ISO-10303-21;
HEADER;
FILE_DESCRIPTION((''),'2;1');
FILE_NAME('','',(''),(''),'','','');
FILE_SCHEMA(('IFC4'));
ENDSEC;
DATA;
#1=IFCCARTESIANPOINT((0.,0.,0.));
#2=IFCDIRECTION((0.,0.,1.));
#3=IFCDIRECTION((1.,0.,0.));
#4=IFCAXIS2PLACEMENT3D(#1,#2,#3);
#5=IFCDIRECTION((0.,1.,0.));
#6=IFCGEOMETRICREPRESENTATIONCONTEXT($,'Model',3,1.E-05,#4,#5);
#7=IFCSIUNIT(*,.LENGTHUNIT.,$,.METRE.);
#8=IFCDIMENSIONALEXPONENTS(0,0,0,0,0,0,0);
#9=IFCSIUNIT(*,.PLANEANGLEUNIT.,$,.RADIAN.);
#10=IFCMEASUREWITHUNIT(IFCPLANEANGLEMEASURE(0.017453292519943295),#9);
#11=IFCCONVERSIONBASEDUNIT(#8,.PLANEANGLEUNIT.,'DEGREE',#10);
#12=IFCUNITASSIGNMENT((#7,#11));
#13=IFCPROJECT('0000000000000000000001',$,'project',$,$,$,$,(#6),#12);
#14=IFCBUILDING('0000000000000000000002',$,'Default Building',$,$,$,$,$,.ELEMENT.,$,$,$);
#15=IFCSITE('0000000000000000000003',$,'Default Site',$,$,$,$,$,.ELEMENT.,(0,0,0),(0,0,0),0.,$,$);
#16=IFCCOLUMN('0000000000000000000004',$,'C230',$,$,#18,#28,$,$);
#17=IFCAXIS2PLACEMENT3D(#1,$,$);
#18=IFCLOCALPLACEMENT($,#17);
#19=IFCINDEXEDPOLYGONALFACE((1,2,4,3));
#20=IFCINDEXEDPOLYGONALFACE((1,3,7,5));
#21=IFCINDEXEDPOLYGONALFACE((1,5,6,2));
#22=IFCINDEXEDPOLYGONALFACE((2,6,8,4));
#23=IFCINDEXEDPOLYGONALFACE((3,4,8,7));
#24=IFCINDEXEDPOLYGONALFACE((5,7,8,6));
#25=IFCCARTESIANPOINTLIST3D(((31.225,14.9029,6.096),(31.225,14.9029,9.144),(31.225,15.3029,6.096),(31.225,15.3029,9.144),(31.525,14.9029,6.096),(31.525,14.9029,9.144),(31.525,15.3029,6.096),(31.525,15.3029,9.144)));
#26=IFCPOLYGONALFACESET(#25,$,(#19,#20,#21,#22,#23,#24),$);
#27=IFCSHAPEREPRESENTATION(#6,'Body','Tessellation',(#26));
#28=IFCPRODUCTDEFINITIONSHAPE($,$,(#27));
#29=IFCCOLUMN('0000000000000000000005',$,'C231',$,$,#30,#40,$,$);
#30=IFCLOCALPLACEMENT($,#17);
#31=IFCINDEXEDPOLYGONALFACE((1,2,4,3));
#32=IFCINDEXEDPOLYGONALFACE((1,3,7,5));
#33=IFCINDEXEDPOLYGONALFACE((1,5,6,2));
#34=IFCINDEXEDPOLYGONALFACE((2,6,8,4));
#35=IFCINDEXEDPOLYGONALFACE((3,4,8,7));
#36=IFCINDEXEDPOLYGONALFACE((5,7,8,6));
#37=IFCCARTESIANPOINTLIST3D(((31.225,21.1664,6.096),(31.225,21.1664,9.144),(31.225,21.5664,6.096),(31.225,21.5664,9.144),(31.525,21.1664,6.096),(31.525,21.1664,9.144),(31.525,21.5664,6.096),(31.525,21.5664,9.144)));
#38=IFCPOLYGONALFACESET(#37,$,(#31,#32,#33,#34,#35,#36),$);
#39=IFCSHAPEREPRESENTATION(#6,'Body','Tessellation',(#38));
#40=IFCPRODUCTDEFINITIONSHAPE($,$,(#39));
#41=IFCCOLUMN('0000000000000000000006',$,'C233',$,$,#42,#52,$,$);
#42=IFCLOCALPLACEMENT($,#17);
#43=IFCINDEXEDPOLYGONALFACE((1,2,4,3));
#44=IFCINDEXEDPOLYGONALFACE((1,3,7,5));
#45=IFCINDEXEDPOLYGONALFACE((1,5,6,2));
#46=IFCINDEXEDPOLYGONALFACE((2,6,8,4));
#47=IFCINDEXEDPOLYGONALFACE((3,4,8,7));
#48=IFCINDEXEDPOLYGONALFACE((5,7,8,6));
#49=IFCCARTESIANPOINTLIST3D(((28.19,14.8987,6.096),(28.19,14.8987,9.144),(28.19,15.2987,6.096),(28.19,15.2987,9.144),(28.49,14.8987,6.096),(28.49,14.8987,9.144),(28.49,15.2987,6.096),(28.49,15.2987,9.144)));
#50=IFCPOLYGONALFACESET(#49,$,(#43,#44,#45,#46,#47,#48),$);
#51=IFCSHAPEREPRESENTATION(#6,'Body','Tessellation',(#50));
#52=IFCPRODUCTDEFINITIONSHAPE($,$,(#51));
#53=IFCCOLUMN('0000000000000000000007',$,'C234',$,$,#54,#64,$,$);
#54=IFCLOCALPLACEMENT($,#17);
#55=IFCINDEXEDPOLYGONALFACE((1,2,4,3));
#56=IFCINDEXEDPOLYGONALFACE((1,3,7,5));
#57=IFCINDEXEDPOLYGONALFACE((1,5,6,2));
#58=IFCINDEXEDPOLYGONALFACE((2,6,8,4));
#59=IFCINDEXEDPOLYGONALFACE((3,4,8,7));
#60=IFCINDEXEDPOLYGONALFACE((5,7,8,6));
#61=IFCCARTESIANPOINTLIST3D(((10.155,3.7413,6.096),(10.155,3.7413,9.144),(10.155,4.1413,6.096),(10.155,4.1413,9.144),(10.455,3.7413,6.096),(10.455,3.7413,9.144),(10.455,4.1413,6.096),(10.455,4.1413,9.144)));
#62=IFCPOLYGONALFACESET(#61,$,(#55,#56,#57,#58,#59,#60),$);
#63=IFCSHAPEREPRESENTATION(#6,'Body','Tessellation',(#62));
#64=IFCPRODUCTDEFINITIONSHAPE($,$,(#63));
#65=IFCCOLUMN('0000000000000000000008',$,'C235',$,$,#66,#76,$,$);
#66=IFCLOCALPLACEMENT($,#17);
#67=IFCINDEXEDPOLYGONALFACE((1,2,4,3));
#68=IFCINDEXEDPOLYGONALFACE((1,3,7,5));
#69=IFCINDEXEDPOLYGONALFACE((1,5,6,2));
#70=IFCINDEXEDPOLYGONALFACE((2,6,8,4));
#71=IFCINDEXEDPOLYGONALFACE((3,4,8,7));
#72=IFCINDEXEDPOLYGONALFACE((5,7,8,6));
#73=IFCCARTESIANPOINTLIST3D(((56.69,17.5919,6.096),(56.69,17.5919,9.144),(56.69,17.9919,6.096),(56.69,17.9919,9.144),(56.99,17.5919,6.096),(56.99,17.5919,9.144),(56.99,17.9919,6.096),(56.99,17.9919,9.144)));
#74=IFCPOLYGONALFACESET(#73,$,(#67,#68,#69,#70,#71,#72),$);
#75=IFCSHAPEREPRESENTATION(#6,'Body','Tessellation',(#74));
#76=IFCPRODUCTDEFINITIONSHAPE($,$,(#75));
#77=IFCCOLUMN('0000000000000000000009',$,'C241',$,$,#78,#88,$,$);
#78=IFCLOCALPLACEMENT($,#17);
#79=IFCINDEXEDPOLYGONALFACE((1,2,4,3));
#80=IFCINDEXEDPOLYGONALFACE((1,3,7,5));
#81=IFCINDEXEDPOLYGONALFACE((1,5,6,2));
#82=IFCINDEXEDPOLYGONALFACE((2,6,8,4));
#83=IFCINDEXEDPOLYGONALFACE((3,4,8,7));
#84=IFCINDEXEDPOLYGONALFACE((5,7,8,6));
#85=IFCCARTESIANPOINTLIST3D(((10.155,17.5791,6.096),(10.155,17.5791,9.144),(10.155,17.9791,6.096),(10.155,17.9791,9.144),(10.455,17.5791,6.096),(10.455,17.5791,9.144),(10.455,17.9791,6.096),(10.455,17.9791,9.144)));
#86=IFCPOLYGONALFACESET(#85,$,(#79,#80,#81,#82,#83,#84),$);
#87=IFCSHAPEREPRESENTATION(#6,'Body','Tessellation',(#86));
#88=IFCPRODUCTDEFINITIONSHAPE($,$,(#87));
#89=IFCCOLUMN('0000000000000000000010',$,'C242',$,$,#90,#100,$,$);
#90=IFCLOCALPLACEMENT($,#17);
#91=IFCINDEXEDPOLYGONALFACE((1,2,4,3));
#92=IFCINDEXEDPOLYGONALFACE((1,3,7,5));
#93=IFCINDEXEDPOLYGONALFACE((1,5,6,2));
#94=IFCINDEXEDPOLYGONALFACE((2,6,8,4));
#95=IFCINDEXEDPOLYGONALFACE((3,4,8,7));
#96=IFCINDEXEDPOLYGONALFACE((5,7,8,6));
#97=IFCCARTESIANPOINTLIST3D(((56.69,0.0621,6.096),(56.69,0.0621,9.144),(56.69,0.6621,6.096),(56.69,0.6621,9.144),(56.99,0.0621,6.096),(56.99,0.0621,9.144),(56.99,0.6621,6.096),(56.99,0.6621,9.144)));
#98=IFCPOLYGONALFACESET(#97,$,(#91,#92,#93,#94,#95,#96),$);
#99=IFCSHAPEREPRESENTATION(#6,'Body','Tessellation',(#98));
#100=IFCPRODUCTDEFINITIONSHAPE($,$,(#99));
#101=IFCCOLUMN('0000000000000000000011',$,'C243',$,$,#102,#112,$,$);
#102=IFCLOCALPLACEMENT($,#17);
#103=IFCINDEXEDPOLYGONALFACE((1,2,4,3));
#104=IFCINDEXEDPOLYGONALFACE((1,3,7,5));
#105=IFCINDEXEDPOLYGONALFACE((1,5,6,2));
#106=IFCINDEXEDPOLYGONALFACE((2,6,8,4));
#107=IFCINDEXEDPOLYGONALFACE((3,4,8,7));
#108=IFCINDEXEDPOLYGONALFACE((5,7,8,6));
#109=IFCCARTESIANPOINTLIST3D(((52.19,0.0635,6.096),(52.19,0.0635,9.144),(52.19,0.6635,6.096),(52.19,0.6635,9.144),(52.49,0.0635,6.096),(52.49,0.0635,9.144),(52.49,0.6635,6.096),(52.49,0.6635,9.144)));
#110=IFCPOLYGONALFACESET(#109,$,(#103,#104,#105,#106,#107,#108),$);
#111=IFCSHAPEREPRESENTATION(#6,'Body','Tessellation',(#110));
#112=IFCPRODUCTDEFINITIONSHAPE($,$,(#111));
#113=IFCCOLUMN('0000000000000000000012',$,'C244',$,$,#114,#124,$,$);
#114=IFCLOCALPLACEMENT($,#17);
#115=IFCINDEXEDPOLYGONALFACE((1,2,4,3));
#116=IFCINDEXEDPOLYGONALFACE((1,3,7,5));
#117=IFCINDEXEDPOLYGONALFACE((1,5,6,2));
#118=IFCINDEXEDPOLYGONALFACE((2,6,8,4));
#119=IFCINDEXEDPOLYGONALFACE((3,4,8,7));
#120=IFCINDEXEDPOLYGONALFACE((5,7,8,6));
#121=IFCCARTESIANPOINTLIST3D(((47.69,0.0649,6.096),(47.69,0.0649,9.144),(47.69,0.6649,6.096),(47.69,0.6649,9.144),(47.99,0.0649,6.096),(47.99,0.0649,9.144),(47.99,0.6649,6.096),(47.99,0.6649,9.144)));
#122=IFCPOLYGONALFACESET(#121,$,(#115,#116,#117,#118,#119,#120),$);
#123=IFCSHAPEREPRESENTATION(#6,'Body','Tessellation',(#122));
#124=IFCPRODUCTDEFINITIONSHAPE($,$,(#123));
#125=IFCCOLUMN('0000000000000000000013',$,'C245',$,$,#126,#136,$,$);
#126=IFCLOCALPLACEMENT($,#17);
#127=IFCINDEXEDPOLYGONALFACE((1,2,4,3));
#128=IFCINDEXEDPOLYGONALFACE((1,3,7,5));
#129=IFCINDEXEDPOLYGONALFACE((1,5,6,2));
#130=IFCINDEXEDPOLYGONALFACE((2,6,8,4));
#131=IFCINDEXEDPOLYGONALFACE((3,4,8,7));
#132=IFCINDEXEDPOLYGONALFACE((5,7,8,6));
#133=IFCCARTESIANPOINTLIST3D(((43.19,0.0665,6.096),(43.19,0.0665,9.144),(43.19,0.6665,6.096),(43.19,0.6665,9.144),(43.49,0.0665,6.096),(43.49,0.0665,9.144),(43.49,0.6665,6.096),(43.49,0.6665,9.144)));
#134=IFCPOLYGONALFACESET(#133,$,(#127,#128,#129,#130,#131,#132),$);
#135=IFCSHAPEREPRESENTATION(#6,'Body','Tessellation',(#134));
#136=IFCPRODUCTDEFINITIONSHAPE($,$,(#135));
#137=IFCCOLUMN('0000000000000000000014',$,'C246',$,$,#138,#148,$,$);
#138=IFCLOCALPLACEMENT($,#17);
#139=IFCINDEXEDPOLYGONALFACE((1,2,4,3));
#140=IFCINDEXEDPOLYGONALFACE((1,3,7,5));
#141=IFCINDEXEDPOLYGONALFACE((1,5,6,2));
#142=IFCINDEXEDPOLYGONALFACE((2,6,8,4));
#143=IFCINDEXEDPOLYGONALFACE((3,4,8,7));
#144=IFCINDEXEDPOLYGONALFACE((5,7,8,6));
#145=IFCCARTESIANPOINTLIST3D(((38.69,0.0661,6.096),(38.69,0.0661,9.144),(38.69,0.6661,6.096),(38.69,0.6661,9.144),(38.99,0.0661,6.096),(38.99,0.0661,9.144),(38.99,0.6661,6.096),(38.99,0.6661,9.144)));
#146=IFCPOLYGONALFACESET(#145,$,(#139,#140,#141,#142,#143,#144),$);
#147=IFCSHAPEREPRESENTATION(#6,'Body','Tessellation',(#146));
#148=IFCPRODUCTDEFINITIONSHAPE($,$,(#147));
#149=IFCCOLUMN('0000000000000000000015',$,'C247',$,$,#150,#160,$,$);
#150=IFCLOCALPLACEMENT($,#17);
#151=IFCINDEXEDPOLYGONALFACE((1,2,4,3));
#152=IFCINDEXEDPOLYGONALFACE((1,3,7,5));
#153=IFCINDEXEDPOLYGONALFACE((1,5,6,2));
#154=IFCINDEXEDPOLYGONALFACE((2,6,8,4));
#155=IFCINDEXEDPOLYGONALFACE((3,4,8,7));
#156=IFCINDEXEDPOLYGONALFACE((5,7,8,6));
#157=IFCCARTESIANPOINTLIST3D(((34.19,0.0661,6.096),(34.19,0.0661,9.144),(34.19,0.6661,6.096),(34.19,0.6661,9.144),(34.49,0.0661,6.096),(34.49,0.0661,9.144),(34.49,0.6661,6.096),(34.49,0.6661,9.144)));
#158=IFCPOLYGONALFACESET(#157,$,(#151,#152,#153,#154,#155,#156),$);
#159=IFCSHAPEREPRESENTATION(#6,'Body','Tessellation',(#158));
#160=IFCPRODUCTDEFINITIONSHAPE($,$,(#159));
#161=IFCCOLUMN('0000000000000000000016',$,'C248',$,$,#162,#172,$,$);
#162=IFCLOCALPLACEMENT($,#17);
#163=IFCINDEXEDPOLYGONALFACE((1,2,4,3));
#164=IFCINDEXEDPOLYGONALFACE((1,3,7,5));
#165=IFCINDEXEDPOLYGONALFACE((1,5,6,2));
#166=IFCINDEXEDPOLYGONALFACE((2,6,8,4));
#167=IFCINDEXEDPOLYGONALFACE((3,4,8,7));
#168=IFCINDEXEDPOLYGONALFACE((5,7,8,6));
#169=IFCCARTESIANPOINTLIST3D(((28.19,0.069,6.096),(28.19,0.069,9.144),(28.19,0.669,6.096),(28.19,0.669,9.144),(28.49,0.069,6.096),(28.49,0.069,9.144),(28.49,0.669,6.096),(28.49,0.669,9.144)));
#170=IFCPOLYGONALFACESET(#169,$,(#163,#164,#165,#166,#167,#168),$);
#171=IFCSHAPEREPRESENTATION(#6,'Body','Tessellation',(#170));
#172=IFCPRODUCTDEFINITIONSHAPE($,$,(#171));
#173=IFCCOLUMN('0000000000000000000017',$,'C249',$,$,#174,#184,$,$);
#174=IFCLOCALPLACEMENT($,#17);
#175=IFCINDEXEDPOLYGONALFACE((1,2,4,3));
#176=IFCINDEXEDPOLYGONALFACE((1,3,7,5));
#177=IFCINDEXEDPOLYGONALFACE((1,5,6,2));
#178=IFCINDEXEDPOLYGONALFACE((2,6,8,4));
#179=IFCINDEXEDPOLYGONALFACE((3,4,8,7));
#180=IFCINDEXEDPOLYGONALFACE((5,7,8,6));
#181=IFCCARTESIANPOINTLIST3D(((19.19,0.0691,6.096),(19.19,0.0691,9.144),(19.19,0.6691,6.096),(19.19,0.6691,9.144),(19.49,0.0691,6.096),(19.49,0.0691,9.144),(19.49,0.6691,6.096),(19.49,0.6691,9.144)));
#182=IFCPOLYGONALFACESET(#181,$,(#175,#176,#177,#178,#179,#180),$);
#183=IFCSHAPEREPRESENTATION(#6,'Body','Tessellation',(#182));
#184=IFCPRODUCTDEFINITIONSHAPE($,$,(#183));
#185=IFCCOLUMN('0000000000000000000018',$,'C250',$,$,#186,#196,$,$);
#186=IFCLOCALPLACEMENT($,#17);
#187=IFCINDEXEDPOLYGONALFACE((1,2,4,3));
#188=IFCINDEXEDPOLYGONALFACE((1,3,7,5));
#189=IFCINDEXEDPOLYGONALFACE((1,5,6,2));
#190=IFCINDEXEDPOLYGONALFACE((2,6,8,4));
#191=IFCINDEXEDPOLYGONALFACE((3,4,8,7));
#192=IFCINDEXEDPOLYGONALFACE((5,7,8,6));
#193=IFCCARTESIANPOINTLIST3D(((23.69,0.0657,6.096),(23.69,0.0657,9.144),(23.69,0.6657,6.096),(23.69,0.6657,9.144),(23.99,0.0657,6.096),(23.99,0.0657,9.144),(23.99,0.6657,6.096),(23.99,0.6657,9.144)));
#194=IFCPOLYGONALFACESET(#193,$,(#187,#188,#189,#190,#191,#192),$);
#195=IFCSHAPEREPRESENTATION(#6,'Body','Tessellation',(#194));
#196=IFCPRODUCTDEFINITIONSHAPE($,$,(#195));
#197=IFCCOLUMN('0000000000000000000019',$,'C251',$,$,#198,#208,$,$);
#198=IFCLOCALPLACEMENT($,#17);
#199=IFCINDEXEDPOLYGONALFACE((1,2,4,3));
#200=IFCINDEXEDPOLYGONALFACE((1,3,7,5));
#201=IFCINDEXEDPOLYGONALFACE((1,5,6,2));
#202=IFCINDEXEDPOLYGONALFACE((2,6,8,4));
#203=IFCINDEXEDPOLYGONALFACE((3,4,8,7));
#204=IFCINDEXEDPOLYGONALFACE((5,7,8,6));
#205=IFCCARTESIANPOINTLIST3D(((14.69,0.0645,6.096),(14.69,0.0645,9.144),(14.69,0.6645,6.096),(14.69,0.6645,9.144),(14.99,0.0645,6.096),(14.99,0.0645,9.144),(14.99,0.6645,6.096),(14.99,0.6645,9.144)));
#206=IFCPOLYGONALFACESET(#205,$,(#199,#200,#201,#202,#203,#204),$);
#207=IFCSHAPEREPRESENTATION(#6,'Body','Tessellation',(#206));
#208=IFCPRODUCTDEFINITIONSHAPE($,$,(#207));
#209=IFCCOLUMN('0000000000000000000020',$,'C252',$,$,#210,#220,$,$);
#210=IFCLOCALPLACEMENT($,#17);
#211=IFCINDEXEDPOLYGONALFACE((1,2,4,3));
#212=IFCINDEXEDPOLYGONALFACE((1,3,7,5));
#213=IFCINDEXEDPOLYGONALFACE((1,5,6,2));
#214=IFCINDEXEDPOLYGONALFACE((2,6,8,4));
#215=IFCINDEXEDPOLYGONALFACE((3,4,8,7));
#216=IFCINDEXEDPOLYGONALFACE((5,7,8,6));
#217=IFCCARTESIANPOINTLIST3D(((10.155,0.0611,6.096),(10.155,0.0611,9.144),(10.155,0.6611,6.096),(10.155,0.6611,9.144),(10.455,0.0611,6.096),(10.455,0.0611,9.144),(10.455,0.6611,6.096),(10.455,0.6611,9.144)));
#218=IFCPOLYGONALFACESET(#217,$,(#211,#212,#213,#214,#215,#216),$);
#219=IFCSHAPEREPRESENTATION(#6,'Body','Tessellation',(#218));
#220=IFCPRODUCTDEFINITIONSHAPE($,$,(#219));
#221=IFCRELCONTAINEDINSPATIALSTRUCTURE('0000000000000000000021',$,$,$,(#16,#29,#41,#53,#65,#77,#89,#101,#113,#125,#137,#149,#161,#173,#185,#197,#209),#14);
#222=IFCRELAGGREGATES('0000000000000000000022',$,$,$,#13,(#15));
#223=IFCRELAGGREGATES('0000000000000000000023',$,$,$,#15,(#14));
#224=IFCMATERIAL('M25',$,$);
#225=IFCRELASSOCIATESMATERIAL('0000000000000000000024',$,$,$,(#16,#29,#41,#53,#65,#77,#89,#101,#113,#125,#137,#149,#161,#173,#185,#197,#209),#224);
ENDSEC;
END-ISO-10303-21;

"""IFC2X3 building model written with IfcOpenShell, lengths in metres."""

from ifc_helpers import new_model, entity, si_unit, converted_unit, direction, frame, frame_2d, origin_with_axes, place, context, project, spatial, rectangle, extrude, material, element, save


model = new_model("IFC2X3")

# Units and contexts
model_context = context("Model", 3, precision=1e-05, world=origin_with_axes(), true_north=direction((0.0, 1.0, 0.0)))
ifc_project = project(units=[si_unit("LENGTHUNIT", "METRE"), converted_unit("PLANEANGLEUNIT", "DEGREE", entity("IfcPlaneAngleMeasure", 0.017453292519943295), si_unit("PLANEANGLEUNIT", "RADIAN"), dimensions=[0, 0, 0, 0, 0, 0, 0])], contexts=[model_context])

# Site, building
site = spatial("IfcSite", under=ifc_project, Name="Default Site", CompositionType="ELEMENT", RefLatitude=(0, 0, 0), RefLongitude=(0, 0, 0), RefElevation=0.0)
building = spatial("IfcBuilding", under=site, Name="Default Building", CompositionType="ELEMENT")

# Columns
ifc_material = material(Name="M25")
placement = place(None, origin_with_axes())
element("IfcColumn", 1, at=placement, inside=building, material=ifc_material, Name="C230", context=model_context, shape_type="SweptSolid", body=[
    extrude(rectangle(XDim=0.3, YDim=0.4, at=frame_2d((0.0, 0.0), x_axis=(1.0, 0.0, 0.0))), frame((31.375, 15.1029, 6.096), z_axis=(0.0, 0.0, 1.0), x_axis=(1.0, 0.0, 0.0)), (0.0, 0.0, 1.0), 3.048),
])
element("IfcColumn", 2, at=placement, inside=building, material=ifc_material, Name="C231", context=model_context, shape_type="SweptSolid", body=[
    extrude(rectangle(XDim=0.3, YDim=0.4, at=frame_2d((0.0, 0.0), x_axis=(1.0, 0.0, 0.0))), frame((31.375, 21.3664, 6.096), z_axis=(0.0, 0.0, 1.0), x_axis=(1.0, 0.0, 0.0)), (0.0, 0.0, 1.0), 3.048),
])
element("IfcColumn", 3, at=placement, inside=building, material=ifc_material, Name="C233", context=model_context, shape_type="SweptSolid", body=[
    extrude(rectangle(XDim=0.3, YDim=0.4, at=frame_2d((0.0, 0.0), x_axis=(1.0, 0.0, 0.0))), frame((28.34, 15.0987, 6.096), z_axis=(0.0, 0.0, 1.0), x_axis=(1.0, 0.0, 0.0)), (0.0, 0.0, 1.0), 3.048),
])
element("IfcColumn", 4, at=placement, inside=building, material=ifc_material, Name="C234", context=model_context, shape_type="SweptSolid", body=[
    extrude(rectangle(XDim=0.3, YDim=0.4, at=frame_2d((0.0, 0.0), x_axis=(1.0, 0.0, 0.0))), frame((10.305, 3.9413, 6.096), z_axis=(0.0, 0.0, 1.0), x_axis=(1.0, 0.0, 0.0)), (0.0, 0.0, 1.0), 3.048),
])
element("IfcColumn", 5, at=placement, inside=building, material=ifc_material, Name="C235", context=model_context, shape_type="SweptSolid", body=[
    extrude(rectangle(XDim=0.3, YDim=0.4, at=frame_2d((0.0, 0.0), x_axis=(1.0, 0.0, 0.0))), frame((56.84, 17.7919, 6.096), z_axis=(0.0, 0.0, 1.0), x_axis=(1.0, 0.0, 0.0)), (0.0, 0.0, 1.0), 3.048),
])
element("IfcColumn", 6, at=placement, inside=building, material=ifc_material, Name="C241", context=model_context, shape_type="SweptSolid", body=[
    extrude(rectangle(XDim=0.3, YDim=0.4, at=frame_2d((0.0, 0.0), x_axis=(1.0, 0.0, 0.0))), frame((10.305, 17.7791, 6.096), z_axis=(0.0, 0.0, 1.0), x_axis=(1.0, 0.0, 0.0)), (0.0, 0.0, 1.0), 3.048),
])
element("IfcColumn", 7, at=placement, inside=building, material=ifc_material, Name="C242", context=model_context, shape_type="SweptSolid", body=[
    extrude(rectangle(XDim=0.3, YDim=0.6, at=frame_2d((0.0, 0.0), x_axis=(1.0, 0.0, 0.0))), frame((56.84, 0.3621, 6.096), z_axis=(0.0, 0.0, 1.0), x_axis=(1.0, 0.0, 0.0)), (0.0, 0.0, 1.0), 3.048),
])
element("IfcColumn", 8, at=placement, inside=building, material=ifc_material, Name="C243", context=model_context, shape_type="SweptSolid", body=[
    extrude(rectangle(XDim=0.3, YDim=0.6, at=frame_2d((0.0, 0.0), x_axis=(1.0, 0.0, 0.0))), frame((52.34, 0.3635, 6.096), z_axis=(0.0, 0.0, 1.0), x_axis=(1.0, 0.0, 0.0)), (0.0, 0.0, 1.0), 3.048),
])
element("IfcColumn", 9, at=placement, inside=building, material=ifc_material, Name="C244", context=model_context, shape_type="SweptSolid", body=[
    extrude(rectangle(XDim=0.3, YDim=0.6, at=frame_2d((0.0, 0.0), x_axis=(1.0, 0.0, 0.0))), frame((47.84, 0.3649, 6.096), z_axis=(0.0, 0.0, 1.0), x_axis=(1.0, 0.0, 0.0)), (0.0, 0.0, 1.0), 3.048),
])
element("IfcColumn", 10, at=placement, inside=building, material=ifc_material, Name="C245", context=model_context, shape_type="SweptSolid", body=[
    extrude(rectangle(XDim=0.3, YDim=0.6, at=frame_2d((0.0, 0.0), x_axis=(1.0, 0.0, 0.0))), frame((43.34, 0.3665, 6.096), z_axis=(0.0, 0.0, 1.0), x_axis=(1.0, 0.0, 0.0)), (0.0, 0.0, 1.0), 3.048),
])
element("IfcColumn", 11, at=placement, inside=building, material=ifc_material, Name="C246", context=model_context, shape_type="SweptSolid", body=[
    extrude(rectangle(XDim=0.3, YDim=0.6, at=frame_2d((0.0, 0.0), x_axis=(1.0, 0.0, 0.0))), frame((38.84, 0.3661, 6.096), z_axis=(0.0, 0.0, 1.0), x_axis=(1.0, 0.0, 0.0)), (0.0, 0.0, 1.0), 3.048),
])
element("IfcColumn", 12, at=placement, inside=building, material=ifc_material, Name="C247", context=model_context, shape_type="SweptSolid", body=[
    extrude(rectangle(XDim=0.3, YDim=0.6, at=frame_2d((0.0, 0.0), x_axis=(1.0, 0.0, 0.0))), frame((34.34, 0.3661, 6.096), z_axis=(0.0, 0.0, 1.0), x_axis=(1.0, 0.0, 0.0)), (0.0, 0.0, 1.0), 3.048),
])
element("IfcColumn", 13, at=placement, inside=building, material=ifc_material, Name="C248", context=model_context, shape_type="SweptSolid", body=[
    extrude(rectangle(XDim=0.3, YDim=0.6, at=frame_2d((0.0, 0.0), x_axis=(1.0, 0.0, 0.0))), frame((28.34, 0.369, 6.096), z_axis=(0.0, 0.0, 1.0), x_axis=(1.0, 0.0, 0.0)), (0.0, 0.0, 1.0), 3.048),
])
element("IfcColumn", 14, at=placement, inside=building, material=ifc_material, Name="C249", context=model_context, shape_type="SweptSolid", body=[
    extrude(rectangle(XDim=0.3, YDim=0.6, at=frame_2d((0.0, 0.0), x_axis=(1.0, 0.0, 0.0))), frame((19.34, 0.3691, 6.096), z_axis=(0.0, 0.0, 1.0), x_axis=(1.0, 0.0, 0.0)), (0.0, 0.0, 1.0), 3.048),
])
element("IfcColumn", 15, at=placement, inside=building, material=ifc_material, Name="C250", context=model_context, shape_type="SweptSolid", body=[
    extrude(rectangle(XDim=0.3, YDim=0.6, at=frame_2d((0.0, 0.0), x_axis=(1.0, 0.0, 0.0))), frame((23.84, 0.3657, 6.096), z_axis=(0.0, 0.0, 1.0), x_axis=(1.0, 0.0, 0.0)), (0.0, 0.0, 1.0), 3.048),
])
element("IfcColumn", 16, at=placement, inside=building, material=ifc_material, Name="C251", context=model_context, shape_type="SweptSolid", body=[
    extrude(rectangle(XDim=0.3, YDim=0.6, at=frame_2d((0.0, 0.0), x_axis=(1.0, 0.0, 0.0))), frame((14.84, 0.3645, 6.096), z_axis=(0.0, 0.0, 1.0), x_axis=(1.0, 0.0, 0.0)), (0.0, 0.0, 1.0), 3.048),
])
element("IfcColumn", 17, at=placement, inside=building, material=ifc_material, Name="C252", context=model_context, shape_type="SweptSolid", body=[
    extrude(rectangle(XDim=0.3, YDim=0.6, at=frame_2d((0.0, 0.0), x_axis=(1.0, 0.0, 0.0))), frame((10.305, 0.3611, 6.096), z_axis=(0.0, 0.0, 1.0), x_axis=(1.0, 0.0, 0.0)), (0.0, 0.0, 1.0), 3.048),
])

save(model, "model.ifc")
